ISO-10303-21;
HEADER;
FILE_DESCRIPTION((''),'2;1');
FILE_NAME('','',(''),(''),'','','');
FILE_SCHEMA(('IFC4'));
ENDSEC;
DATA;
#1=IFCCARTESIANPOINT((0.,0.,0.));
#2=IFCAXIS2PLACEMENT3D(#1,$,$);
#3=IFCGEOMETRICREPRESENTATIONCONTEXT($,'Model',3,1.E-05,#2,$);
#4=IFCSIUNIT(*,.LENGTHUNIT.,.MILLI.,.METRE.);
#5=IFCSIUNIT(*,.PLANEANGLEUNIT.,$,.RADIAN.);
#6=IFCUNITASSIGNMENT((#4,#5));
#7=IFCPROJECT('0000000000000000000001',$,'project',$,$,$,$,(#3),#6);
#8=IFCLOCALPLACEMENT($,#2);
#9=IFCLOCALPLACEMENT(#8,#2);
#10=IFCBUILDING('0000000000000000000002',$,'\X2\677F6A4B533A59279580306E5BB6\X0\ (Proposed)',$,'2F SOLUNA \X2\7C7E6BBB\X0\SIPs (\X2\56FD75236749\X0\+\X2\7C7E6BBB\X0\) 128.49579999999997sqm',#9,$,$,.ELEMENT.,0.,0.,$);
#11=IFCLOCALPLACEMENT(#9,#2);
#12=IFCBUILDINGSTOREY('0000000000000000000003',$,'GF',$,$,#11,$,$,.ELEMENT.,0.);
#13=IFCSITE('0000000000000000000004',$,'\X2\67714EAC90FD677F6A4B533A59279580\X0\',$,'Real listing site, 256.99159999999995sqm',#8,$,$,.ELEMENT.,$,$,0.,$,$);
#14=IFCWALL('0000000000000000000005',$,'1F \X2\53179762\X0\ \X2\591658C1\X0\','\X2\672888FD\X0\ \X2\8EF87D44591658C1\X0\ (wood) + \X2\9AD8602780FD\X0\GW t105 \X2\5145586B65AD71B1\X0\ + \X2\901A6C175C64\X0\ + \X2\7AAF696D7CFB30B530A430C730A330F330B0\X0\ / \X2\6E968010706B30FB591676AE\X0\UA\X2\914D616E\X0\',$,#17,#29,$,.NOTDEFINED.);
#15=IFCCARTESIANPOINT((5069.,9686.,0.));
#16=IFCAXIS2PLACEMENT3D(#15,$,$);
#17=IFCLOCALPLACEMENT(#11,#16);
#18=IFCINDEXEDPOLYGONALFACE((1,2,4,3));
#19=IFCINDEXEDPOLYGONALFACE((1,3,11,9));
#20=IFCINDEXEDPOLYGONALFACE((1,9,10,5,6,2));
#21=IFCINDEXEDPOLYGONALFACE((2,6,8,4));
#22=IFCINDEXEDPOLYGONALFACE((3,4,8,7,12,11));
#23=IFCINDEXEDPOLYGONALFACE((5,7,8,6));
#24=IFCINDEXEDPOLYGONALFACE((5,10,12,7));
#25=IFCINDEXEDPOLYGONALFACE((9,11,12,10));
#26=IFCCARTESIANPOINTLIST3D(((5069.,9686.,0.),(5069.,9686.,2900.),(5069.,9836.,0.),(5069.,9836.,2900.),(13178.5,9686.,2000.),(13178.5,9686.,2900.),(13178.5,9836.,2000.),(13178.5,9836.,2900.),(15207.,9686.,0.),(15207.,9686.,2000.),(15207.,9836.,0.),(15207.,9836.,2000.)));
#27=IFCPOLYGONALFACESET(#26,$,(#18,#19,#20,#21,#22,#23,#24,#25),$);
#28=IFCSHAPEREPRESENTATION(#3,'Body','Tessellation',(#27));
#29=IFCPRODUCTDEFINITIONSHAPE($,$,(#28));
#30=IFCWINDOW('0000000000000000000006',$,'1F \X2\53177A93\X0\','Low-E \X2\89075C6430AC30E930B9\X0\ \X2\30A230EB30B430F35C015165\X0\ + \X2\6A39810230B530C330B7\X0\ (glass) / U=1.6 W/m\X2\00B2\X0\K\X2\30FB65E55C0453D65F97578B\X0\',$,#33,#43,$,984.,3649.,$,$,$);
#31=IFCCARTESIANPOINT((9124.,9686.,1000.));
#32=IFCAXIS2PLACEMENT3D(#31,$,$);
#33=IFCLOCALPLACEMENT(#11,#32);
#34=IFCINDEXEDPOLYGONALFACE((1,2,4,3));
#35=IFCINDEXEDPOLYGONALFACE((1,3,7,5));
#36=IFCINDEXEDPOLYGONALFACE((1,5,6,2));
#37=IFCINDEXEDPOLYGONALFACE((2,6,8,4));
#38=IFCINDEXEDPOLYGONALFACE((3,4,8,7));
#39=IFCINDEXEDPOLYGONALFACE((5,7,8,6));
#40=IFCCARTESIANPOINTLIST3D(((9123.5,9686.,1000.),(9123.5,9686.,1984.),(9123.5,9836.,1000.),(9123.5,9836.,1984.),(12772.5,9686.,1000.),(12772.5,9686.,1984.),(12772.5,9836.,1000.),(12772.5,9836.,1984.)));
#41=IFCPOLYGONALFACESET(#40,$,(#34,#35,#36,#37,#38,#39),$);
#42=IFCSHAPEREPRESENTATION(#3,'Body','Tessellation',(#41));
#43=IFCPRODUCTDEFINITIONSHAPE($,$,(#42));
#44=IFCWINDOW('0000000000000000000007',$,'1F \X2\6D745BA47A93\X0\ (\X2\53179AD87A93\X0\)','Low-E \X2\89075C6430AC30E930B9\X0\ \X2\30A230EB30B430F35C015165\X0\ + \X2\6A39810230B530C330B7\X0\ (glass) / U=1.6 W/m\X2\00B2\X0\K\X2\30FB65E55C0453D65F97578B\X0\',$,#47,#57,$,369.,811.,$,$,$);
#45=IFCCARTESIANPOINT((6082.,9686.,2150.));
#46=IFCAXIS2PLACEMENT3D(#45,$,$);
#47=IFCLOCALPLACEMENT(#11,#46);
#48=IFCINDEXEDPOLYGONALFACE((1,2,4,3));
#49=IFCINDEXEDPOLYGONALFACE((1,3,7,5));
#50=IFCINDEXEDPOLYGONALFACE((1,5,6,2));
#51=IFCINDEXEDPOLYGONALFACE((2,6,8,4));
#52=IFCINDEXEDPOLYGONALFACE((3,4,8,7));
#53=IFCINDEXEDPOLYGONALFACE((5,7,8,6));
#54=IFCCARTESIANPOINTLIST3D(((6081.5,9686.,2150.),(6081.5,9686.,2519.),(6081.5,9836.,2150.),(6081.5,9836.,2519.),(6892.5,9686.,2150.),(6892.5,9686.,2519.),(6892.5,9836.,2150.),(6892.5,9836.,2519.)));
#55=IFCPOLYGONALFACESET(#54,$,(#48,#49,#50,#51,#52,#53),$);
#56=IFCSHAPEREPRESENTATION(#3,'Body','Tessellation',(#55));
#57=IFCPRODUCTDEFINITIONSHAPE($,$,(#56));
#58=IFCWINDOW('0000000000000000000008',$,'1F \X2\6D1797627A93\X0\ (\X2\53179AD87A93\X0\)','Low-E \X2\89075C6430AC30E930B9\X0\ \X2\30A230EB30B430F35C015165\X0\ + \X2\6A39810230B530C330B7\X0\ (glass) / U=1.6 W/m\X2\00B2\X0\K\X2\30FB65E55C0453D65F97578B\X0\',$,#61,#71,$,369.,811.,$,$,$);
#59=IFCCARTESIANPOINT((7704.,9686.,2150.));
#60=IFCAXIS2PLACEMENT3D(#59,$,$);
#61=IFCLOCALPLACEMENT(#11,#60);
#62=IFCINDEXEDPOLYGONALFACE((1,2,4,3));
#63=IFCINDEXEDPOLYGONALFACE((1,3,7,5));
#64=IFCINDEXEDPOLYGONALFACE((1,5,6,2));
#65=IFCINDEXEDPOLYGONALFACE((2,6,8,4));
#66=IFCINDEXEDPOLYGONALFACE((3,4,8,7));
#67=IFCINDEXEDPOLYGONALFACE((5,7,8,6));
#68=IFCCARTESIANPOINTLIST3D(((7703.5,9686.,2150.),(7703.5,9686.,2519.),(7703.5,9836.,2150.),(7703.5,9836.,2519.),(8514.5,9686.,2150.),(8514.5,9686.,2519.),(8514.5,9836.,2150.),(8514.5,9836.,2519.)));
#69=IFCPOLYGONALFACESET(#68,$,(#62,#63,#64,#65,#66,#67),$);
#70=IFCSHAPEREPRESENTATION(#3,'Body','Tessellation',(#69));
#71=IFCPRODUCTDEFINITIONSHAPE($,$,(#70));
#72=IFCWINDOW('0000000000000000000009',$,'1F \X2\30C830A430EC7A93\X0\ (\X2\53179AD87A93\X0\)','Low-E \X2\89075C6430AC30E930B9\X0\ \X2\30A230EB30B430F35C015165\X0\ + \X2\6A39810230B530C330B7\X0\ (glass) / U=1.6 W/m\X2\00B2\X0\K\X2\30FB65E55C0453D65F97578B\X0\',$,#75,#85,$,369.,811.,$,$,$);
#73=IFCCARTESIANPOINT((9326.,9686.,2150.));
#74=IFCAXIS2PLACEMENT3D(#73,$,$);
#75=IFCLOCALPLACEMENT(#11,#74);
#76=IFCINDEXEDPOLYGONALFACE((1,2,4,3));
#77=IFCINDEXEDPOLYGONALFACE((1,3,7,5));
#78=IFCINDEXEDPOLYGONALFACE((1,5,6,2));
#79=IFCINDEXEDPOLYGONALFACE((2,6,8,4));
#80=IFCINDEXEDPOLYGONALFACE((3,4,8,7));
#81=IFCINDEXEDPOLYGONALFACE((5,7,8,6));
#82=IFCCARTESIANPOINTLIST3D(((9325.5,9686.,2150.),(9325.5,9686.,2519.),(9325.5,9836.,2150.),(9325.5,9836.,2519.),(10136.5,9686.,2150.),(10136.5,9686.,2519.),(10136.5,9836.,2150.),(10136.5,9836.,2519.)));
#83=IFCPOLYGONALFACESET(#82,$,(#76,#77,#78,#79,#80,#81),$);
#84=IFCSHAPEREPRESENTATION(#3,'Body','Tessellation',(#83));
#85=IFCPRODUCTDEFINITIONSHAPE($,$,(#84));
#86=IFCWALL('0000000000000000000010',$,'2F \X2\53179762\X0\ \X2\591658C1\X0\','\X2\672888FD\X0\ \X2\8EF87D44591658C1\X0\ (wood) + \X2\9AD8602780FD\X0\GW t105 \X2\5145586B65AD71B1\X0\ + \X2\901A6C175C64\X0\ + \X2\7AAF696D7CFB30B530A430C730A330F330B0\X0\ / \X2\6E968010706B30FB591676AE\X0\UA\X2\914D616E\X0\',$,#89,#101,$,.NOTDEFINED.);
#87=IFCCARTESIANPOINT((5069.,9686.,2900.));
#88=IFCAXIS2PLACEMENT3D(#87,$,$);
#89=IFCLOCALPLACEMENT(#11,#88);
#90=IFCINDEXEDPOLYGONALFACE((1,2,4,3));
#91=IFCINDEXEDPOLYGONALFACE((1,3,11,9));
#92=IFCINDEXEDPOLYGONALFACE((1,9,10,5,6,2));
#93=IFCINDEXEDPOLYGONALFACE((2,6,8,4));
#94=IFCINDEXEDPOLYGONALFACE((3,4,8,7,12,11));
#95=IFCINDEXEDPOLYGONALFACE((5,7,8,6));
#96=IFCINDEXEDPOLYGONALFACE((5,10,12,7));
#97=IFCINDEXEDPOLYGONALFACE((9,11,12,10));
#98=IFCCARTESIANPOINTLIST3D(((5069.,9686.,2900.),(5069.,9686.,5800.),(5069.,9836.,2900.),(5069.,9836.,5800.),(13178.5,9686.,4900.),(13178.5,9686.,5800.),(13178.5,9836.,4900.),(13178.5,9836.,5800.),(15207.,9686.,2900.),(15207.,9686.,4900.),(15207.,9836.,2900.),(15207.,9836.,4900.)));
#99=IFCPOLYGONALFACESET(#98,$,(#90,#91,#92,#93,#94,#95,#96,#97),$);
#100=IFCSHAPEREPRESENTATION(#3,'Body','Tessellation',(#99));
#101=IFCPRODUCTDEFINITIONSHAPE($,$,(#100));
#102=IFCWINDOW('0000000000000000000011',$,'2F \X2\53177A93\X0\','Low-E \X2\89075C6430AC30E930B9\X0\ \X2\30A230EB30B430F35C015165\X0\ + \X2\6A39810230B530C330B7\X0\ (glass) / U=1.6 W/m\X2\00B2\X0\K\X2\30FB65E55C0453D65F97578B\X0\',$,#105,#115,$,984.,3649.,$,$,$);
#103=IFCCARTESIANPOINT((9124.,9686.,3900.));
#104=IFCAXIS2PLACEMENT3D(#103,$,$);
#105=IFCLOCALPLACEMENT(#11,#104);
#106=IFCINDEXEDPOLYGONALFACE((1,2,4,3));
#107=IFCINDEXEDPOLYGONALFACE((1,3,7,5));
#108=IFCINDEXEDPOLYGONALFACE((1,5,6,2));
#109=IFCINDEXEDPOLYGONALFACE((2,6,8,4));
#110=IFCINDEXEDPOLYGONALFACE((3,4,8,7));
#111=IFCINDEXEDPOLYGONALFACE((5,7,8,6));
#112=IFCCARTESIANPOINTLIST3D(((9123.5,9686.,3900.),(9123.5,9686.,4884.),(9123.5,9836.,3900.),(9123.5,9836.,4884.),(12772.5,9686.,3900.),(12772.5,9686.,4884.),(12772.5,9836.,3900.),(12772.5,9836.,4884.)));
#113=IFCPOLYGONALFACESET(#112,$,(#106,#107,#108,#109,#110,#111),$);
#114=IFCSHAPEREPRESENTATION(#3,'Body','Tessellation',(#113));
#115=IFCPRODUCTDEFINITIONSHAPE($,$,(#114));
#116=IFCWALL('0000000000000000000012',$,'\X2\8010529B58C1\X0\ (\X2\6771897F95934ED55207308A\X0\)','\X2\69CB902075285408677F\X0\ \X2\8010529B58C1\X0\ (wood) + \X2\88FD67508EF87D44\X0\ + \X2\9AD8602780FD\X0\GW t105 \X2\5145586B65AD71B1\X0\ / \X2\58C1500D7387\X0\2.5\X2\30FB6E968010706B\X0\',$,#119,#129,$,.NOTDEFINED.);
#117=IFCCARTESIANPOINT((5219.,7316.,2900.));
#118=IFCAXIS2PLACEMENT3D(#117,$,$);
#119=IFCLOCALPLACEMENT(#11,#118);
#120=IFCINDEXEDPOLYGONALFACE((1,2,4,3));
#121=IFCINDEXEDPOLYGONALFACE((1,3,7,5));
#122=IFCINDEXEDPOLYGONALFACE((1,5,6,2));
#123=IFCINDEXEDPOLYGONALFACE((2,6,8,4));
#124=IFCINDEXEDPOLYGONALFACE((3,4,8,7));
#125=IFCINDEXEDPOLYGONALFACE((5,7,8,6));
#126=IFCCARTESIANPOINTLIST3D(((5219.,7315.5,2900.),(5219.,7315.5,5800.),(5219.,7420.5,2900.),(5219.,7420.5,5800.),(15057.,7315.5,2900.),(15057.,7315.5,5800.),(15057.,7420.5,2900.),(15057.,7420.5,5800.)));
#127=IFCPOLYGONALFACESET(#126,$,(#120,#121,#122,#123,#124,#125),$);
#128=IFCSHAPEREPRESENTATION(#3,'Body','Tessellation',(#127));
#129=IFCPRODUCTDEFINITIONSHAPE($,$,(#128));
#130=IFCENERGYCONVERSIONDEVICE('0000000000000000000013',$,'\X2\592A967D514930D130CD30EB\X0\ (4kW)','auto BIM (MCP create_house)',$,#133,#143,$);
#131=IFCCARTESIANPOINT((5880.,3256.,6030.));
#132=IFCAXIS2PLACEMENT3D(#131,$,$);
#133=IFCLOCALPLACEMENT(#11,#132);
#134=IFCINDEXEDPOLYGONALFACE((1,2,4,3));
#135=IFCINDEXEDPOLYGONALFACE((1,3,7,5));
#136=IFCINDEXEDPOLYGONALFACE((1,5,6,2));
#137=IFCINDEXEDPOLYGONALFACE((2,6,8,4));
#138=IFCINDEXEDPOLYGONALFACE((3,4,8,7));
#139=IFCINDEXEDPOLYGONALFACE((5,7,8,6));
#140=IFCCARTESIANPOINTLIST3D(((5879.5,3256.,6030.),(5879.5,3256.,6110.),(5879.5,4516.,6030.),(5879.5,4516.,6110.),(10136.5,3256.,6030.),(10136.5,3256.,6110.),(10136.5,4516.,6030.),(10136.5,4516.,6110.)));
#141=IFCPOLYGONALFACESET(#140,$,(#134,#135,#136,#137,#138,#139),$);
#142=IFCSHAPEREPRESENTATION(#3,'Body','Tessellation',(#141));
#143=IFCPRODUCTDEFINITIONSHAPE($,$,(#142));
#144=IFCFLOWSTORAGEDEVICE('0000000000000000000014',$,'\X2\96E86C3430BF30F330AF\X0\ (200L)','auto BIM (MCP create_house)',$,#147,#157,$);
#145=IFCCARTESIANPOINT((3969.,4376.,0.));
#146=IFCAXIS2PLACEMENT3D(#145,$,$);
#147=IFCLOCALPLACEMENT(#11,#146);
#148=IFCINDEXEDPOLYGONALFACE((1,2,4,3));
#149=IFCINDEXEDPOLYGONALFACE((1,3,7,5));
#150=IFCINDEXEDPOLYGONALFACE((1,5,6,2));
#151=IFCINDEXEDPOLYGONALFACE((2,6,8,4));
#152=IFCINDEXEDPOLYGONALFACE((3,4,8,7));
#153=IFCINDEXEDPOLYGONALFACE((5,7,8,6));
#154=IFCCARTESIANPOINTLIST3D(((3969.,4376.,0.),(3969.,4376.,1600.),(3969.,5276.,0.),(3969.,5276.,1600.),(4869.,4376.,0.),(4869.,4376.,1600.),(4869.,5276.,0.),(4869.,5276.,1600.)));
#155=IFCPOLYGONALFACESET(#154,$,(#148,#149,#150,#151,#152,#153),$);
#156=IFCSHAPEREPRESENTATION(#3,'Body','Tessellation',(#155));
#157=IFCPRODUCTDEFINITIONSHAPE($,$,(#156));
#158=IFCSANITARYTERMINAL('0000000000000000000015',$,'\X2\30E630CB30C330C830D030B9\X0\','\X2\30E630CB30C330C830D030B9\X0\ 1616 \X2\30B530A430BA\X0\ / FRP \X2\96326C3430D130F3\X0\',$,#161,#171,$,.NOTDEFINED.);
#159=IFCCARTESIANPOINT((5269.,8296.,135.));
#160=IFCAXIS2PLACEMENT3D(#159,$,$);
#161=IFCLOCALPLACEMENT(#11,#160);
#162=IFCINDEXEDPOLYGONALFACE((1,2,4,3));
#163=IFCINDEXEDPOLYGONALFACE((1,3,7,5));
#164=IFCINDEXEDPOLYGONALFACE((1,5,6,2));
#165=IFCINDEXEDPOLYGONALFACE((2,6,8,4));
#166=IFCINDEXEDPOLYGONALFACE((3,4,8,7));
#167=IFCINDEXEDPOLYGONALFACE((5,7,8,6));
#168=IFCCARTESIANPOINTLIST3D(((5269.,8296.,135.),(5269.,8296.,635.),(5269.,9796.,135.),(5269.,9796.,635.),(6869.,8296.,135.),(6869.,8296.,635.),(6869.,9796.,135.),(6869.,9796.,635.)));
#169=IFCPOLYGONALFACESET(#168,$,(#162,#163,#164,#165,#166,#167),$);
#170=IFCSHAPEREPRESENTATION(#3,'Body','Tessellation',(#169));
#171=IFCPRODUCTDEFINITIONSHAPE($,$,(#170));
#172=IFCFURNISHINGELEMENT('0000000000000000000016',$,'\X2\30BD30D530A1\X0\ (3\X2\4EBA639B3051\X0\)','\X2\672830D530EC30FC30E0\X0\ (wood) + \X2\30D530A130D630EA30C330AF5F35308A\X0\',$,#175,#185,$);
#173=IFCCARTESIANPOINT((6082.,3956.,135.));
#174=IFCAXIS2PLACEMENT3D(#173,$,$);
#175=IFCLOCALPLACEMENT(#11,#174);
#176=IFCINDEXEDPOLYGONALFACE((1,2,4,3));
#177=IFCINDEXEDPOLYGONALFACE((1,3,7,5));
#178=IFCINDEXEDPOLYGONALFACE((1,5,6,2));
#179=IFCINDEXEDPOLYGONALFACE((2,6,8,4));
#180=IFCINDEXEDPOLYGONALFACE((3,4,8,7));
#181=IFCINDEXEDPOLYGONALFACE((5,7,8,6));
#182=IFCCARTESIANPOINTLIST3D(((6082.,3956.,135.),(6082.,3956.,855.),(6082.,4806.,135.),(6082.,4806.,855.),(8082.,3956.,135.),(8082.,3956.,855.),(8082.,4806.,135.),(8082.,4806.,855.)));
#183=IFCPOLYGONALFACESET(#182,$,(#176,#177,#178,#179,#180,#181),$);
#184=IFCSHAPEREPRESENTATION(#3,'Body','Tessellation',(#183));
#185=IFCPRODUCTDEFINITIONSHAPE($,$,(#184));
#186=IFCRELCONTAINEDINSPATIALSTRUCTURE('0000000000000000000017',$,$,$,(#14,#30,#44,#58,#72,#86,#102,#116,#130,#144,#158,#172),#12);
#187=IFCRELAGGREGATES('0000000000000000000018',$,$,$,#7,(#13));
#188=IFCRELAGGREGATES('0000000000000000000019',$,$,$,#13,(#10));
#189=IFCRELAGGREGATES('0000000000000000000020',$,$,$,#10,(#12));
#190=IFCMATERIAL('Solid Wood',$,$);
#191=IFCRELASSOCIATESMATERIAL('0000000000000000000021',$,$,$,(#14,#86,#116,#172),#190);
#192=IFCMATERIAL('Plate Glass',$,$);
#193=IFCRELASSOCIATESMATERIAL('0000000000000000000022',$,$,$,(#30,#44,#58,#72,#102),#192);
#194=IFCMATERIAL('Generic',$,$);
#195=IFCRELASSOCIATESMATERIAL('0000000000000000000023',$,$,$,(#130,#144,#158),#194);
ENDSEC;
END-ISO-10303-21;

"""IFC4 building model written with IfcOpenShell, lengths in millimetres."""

from ifc_helpers import new_model, si_unit, frame, frame_2d, origin, place, context, project, spatial, rectangle, extrude, material, element, fill, save


model = new_model("IFC4")

# Units and contexts
model_context = context("Model", 3, precision=1e-05, world=origin())
ifc_project = project(units=[si_unit("LENGTHUNIT", "METRE", prefix="MILLI"), si_unit("PLANEANGLEUNIT", "RADIAN")], contexts=[model_context])

# Site, building, storey
site_placement = place(None, origin())
site = spatial("IfcSite", under=ifc_project, at=site_placement, Name="東京都板橋区大門", ObjectType="Real listing site, 256.99159999999995sqm", CompositionType="ELEMENT", RefElevation=0.0)
building_placement = place(site_placement, origin())
building = spatial("IfcBuilding", under=site, at=building_placement, Name="板橋区大門の家 (Proposed)", ObjectType="2F SOLUNA 籾殻SIPs (国産杉+籾殻) 128.49579999999997sqm", CompositionType="ELEMENT", ElevationOfRefHeight=0.0, ElevationOfTerrain=0.0)
storey_placement = place(building_placement, origin())
storey = spatial("IfcBuildingStorey", under=building, at=storey_placement, Name="GF", CompositionType="ELEMENT", Elevation=0.0)

# Wall, openings, windows
ifc_material_1 = material(Name="Solid Wood")
wall_1_placement = place(storey_placement, frame((5069.0, 9686.0, 0.0)))
wall_1 = element("IfcWall", 1, at=wall_1_placement, inside=storey, material=ifc_material_1, Name="1F 北面 外壁", Description="木製 軸組外壁 (wood) + 高性能GW t105 充填断熱 + 通気層 + 窯業系サイディング / 準耐火・外皮UA配慮", PredefinedType="NOTDEFINED", context=model_context, shape_type="SweptSolid", body=[
    extrude(rectangle(XDim=10138.0, YDim=150.0, at=frame_2d((5069.0, 75.0))), frame((5069.0, 9686.0, 0.0)), (0.0, 0.0, 1.0), 2900.0),
])
opening_1_placement = place(storey_placement, frame((9124.0, 9686.0, 1000.0)))
opening_1 = element("IfcOpeningElement", 2, at=opening_1_placement, cuts=wall_1, PredefinedType="NOTDEFINED", context=model_context, shape_type="SweptSolid", body=[
    extrude(rectangle(XDim=3649.0, YDim=150.0, at=frame_2d((1824.0, 75.0))), frame((9124.0, 9686.0, 1000.0)), (0.0, 0.0, 1.0), 984.0),
])
opening_2_placement = place(storey_placement, frame((6082.0, 9686.0, 2150.0)))
opening_2 = element("IfcOpeningElement", 3, at=opening_2_placement, cuts=wall_1, PredefinedType="NOTDEFINED", context=model_context, shape_type="SweptSolid", body=[
    extrude(rectangle(XDim=811.0, YDim=150.0, at=frame_2d((405.0, 75.0))), frame((6082.0, 9686.0, 2150.0)), (0.0, 0.0, 1.0), 369.0),
])
opening_3_placement = place(storey_placement, frame((7704.0, 9686.0, 2150.0)))
opening_3 = element("IfcOpeningElement", 4, at=opening_3_placement, cuts=wall_1, PredefinedType="NOTDEFINED", context=model_context, shape_type="SweptSolid", body=[
    extrude(rectangle(XDim=811.0, YDim=150.0, at=frame_2d((405.0, 75.0))), frame((7704.0, 9686.0, 2150.0)), (0.0, 0.0, 1.0), 369.0),
])
opening_4_placement = place(storey_placement, frame((9326.0, 9686.0, 2150.0)))
opening_4 = element("IfcOpeningElement", 5, at=opening_4_placement, cuts=wall_1, PredefinedType="NOTDEFINED", context=model_context, shape_type="SweptSolid", body=[
    extrude(rectangle(XDim=811.0, YDim=150.0, at=frame_2d((405.0, 75.0))), frame((9326.0, 9686.0, 2150.0)), (0.0, 0.0, 1.0), 369.0),
])
ifc_material_2 = material(Name="Plate Glass")
window_1_placement = place(storey_placement, frame((9124.0, 9686.0, 1000.0)))
window_1 = element("IfcWindow", 6, at=window_1_placement, inside=storey, material=ifc_material_2, Name="1F 北窓", Description="Low-E 複層ガラス アルゴン封入 + 樹脂サッシ (glass) / U=1.6 W/m²K・日射取得型", OverallHeight=984.0, OverallWidth=3649.0, context=model_context, shape_type="SweptSolid", body=[
    extrude(rectangle(XDim=3649.0, YDim=150.0, at=frame_2d((1824.0, 75.0))), frame((9124.0, 9686.0, 1000.0)), (0.0, 0.0, 1.0), 984.0),
])
fill(opening_1, window_1)
window_2_placement = place(storey_placement, frame((6082.0, 9686.0, 2150.0)))
window_2 = element("IfcWindow", 7, at=window_2_placement, inside=storey, material=ifc_material_2, Name="1F 浴室窓 (北高窓)", Description="Low-E 複層ガラス アルゴン封入 + 樹脂サッシ (glass) / U=1.6 W/m²K・日射取得型", OverallHeight=369.0, OverallWidth=811.0, context=model_context, shape_type="SweptSolid", body=[
    extrude(rectangle(XDim=811.0, YDim=150.0, at=frame_2d((405.0, 75.0))), frame((6082.0, 9686.0, 2150.0)), (0.0, 0.0, 1.0), 369.0),
])
fill(opening_2, window_2)
window_3_placement = place(storey_placement, frame((7704.0, 9686.0, 2150.0)))
window_3 = element("IfcWindow", 8, at=window_3_placement, inside=storey, material=ifc_material_2, Name="1F 洗面窓 (北高窓)", Description="Low-E 複層ガラス アルゴン封入 + 樹脂サッシ (glass) / U=1.6 W/m²K・日射取得型", OverallHeight=369.0, OverallWidth=811.0, context=model_context, shape_type="SweptSolid", body=[
    extrude(rectangle(XDim=811.0, YDim=150.0, at=frame_2d((405.0, 75.0))), frame((7704.0, 9686.0, 2150.0)), (0.0, 0.0, 1.0), 369.0),
])
fill(opening_3, window_3)
window_4_placement = place(storey_placement, frame((9326.0, 9686.0, 2150.0)))
window_4 = element("IfcWindow", 9, at=window_4_placement, inside=storey, material=ifc_material_2, Name="1F トイレ窓 (北高窓)", Description="Low-E 複層ガラス アルゴン封入 + 樹脂サッシ (glass) / U=1.6 W/m²K・日射取得型", OverallHeight=369.0, OverallWidth=811.0, context=model_context, shape_type="SweptSolid", body=[
    extrude(rectangle(XDim=811.0, YDim=150.0, at=frame_2d((405.0, 75.0))), frame((9326.0, 9686.0, 2150.0)), (0.0, 0.0, 1.0), 369.0),
])
fill(opening_4, window_4)

# Wall, opening, window
wall_2_placement = place(storey_placement, frame((5069.0, 9686.0, 2900.0)))
wall_2 = element("IfcWall", 10, at=wall_2_placement, inside=storey, material=ifc_material_1, Name="2F 北面 外壁", Description="木製 軸組外壁 (wood) + 高性能GW t105 充填断熱 + 通気層 + 窯業系サイディング / 準耐火・外皮UA配慮", PredefinedType="NOTDEFINED", context=model_context, shape_type="SweptSolid", body=[
    extrude(rectangle(XDim=10138.0, YDim=150.0, at=frame_2d((5069.0, 75.0))), frame((5069.0, 9686.0, 2900.0)), (0.0, 0.0, 1.0), 2900.0),
])
opening_5_placement = place(storey_placement, frame((9124.0, 9686.0, 3900.0)))
opening_5 = element("IfcOpeningElement", 11, at=opening_5_placement, cuts=wall_2, PredefinedType="NOTDEFINED", context=model_context, shape_type="SweptSolid", body=[
    extrude(rectangle(XDim=3649.0, YDim=150.0, at=frame_2d((1824.0, 75.0))), frame((9124.0, 9686.0, 3900.0)), (0.0, 0.0, 1.0), 984.0),
])
window_5_placement = place(storey_placement, frame((9124.0, 9686.0, 3900.0)))
window_5 = element("IfcWindow", 12, at=window_5_placement, inside=storey, material=ifc_material_2, Name="2F 北窓", Description="Low-E 複層ガラス アルゴン封入 + 樹脂サッシ (glass) / U=1.6 W/m²K・日射取得型", OverallHeight=984.0, OverallWidth=3649.0, context=model_context, shape_type="SweptSolid", body=[
    extrude(rectangle(XDim=3649.0, YDim=150.0, at=frame_2d((1824.0, 75.0))), frame((9124.0, 9686.0, 3900.0)), (0.0, 0.0, 1.0), 984.0),
])
fill(opening_5, window_5)

# Wall
wall_3_placement = place(storey_placement, frame((5219.0, 7316.0, 2900.0)))
element("IfcWall", 13, at=wall_3_placement, inside=storey, material=ifc_material_1, Name="耐力壁 (東西間仕切り)", Description="構造用合板 耐力壁 (wood) + 製材軸組 + 高性能GW t105 充填断熱 / 壁倍率2.5・準耐火", PredefinedType="NOTDEFINED", context=model_context, shape_type="SweptSolid", body=[
    extrude(rectangle(XDim=9838.0, YDim=105.0, at=frame_2d((4919.0, 52.0))), frame((5219.0, 7316.0, 2900.0)), (0.0, 0.0, 1.0), 2900.0),
])

# Energy conversion device
ifc_material_3 = material(Name="Generic")
energy_conversion_device_placement = place(storey_placement, frame((5880.0, 3256.0, 6030.0)))
element("IfcEnergyConversionDevice", 14, at=energy_conversion_device_placement, inside=storey, material=ifc_material_3, Name="太陽光パネル (4kW)", Description="auto BIM (MCP create_house)", context=model_context, shape_type="SweptSolid", body=[
    extrude(rectangle(XDim=4257.0, YDim=1260.0, at=frame_2d((2128.0, 630.0))), frame((5880.0, 3256.0, 6030.0)), (0.0, 0.0, 1.0), 80.0),
])

# Flow storage device
flow_storage_device_placement = place(storey_placement, frame((3969.0, 4376.0, 0.0)))
element("IfcFlowStorageDevice", 15, at=flow_storage_device_placement, inside=storey, material=ifc_material_3, Name="雨水タンク (200L)", Description="auto BIM (MCP create_house)", context=model_context, shape_type="SweptSolid", body=[
    extrude(rectangle(XDim=900.0, YDim=900.0, at=frame_2d((450.0, 450.0))), frame((3969.0, 4376.0, 0.0)), (0.0, 0.0, 1.0), 1600.0),
])

# Sanitary terminal
sanitary_terminal_placement = place(storey_placement, frame((5269.0, 8296.0, 135.0)))
element("IfcSanitaryTerminal", 16, at=sanitary_terminal_placement, inside=storey, material=ifc_material_3, Name="ユニットバス", Description="ユニットバス 1616 サイズ / FRP 防水パン", PredefinedType="NOTDEFINED", context=model_context, shape_type="SweptSolid", body=[
    extrude(rectangle(XDim=1600.0, YDim=1500.0, at=frame_2d((800.0, 750.0))), frame((5269.0, 8296.0, 135.0)), (0.0, 0.0, 1.0), 500.0),
])

# Furnishing element
furnishing_1_placement = place(storey_placement, frame((6082.0, 3956.0, 135.0)))
element("IfcFurnishingElement", 17, at=furnishing_1_placement, inside=storey, material=ifc_material_1, Name="ソファ (3人掛け)", Description="木フレーム (wood) + ファブリック張り", context=model_context, shape_type="SweptSolid", body=[
    extrude(rectangle(XDim=2000.0, YDim=850.0, at=frame_2d((1000.0, 425.0))), frame((6082.0, 3956.0, 135.0)), (0.0, 0.0, 1.0), 720.0),
])

save(model, "model.ifc")
